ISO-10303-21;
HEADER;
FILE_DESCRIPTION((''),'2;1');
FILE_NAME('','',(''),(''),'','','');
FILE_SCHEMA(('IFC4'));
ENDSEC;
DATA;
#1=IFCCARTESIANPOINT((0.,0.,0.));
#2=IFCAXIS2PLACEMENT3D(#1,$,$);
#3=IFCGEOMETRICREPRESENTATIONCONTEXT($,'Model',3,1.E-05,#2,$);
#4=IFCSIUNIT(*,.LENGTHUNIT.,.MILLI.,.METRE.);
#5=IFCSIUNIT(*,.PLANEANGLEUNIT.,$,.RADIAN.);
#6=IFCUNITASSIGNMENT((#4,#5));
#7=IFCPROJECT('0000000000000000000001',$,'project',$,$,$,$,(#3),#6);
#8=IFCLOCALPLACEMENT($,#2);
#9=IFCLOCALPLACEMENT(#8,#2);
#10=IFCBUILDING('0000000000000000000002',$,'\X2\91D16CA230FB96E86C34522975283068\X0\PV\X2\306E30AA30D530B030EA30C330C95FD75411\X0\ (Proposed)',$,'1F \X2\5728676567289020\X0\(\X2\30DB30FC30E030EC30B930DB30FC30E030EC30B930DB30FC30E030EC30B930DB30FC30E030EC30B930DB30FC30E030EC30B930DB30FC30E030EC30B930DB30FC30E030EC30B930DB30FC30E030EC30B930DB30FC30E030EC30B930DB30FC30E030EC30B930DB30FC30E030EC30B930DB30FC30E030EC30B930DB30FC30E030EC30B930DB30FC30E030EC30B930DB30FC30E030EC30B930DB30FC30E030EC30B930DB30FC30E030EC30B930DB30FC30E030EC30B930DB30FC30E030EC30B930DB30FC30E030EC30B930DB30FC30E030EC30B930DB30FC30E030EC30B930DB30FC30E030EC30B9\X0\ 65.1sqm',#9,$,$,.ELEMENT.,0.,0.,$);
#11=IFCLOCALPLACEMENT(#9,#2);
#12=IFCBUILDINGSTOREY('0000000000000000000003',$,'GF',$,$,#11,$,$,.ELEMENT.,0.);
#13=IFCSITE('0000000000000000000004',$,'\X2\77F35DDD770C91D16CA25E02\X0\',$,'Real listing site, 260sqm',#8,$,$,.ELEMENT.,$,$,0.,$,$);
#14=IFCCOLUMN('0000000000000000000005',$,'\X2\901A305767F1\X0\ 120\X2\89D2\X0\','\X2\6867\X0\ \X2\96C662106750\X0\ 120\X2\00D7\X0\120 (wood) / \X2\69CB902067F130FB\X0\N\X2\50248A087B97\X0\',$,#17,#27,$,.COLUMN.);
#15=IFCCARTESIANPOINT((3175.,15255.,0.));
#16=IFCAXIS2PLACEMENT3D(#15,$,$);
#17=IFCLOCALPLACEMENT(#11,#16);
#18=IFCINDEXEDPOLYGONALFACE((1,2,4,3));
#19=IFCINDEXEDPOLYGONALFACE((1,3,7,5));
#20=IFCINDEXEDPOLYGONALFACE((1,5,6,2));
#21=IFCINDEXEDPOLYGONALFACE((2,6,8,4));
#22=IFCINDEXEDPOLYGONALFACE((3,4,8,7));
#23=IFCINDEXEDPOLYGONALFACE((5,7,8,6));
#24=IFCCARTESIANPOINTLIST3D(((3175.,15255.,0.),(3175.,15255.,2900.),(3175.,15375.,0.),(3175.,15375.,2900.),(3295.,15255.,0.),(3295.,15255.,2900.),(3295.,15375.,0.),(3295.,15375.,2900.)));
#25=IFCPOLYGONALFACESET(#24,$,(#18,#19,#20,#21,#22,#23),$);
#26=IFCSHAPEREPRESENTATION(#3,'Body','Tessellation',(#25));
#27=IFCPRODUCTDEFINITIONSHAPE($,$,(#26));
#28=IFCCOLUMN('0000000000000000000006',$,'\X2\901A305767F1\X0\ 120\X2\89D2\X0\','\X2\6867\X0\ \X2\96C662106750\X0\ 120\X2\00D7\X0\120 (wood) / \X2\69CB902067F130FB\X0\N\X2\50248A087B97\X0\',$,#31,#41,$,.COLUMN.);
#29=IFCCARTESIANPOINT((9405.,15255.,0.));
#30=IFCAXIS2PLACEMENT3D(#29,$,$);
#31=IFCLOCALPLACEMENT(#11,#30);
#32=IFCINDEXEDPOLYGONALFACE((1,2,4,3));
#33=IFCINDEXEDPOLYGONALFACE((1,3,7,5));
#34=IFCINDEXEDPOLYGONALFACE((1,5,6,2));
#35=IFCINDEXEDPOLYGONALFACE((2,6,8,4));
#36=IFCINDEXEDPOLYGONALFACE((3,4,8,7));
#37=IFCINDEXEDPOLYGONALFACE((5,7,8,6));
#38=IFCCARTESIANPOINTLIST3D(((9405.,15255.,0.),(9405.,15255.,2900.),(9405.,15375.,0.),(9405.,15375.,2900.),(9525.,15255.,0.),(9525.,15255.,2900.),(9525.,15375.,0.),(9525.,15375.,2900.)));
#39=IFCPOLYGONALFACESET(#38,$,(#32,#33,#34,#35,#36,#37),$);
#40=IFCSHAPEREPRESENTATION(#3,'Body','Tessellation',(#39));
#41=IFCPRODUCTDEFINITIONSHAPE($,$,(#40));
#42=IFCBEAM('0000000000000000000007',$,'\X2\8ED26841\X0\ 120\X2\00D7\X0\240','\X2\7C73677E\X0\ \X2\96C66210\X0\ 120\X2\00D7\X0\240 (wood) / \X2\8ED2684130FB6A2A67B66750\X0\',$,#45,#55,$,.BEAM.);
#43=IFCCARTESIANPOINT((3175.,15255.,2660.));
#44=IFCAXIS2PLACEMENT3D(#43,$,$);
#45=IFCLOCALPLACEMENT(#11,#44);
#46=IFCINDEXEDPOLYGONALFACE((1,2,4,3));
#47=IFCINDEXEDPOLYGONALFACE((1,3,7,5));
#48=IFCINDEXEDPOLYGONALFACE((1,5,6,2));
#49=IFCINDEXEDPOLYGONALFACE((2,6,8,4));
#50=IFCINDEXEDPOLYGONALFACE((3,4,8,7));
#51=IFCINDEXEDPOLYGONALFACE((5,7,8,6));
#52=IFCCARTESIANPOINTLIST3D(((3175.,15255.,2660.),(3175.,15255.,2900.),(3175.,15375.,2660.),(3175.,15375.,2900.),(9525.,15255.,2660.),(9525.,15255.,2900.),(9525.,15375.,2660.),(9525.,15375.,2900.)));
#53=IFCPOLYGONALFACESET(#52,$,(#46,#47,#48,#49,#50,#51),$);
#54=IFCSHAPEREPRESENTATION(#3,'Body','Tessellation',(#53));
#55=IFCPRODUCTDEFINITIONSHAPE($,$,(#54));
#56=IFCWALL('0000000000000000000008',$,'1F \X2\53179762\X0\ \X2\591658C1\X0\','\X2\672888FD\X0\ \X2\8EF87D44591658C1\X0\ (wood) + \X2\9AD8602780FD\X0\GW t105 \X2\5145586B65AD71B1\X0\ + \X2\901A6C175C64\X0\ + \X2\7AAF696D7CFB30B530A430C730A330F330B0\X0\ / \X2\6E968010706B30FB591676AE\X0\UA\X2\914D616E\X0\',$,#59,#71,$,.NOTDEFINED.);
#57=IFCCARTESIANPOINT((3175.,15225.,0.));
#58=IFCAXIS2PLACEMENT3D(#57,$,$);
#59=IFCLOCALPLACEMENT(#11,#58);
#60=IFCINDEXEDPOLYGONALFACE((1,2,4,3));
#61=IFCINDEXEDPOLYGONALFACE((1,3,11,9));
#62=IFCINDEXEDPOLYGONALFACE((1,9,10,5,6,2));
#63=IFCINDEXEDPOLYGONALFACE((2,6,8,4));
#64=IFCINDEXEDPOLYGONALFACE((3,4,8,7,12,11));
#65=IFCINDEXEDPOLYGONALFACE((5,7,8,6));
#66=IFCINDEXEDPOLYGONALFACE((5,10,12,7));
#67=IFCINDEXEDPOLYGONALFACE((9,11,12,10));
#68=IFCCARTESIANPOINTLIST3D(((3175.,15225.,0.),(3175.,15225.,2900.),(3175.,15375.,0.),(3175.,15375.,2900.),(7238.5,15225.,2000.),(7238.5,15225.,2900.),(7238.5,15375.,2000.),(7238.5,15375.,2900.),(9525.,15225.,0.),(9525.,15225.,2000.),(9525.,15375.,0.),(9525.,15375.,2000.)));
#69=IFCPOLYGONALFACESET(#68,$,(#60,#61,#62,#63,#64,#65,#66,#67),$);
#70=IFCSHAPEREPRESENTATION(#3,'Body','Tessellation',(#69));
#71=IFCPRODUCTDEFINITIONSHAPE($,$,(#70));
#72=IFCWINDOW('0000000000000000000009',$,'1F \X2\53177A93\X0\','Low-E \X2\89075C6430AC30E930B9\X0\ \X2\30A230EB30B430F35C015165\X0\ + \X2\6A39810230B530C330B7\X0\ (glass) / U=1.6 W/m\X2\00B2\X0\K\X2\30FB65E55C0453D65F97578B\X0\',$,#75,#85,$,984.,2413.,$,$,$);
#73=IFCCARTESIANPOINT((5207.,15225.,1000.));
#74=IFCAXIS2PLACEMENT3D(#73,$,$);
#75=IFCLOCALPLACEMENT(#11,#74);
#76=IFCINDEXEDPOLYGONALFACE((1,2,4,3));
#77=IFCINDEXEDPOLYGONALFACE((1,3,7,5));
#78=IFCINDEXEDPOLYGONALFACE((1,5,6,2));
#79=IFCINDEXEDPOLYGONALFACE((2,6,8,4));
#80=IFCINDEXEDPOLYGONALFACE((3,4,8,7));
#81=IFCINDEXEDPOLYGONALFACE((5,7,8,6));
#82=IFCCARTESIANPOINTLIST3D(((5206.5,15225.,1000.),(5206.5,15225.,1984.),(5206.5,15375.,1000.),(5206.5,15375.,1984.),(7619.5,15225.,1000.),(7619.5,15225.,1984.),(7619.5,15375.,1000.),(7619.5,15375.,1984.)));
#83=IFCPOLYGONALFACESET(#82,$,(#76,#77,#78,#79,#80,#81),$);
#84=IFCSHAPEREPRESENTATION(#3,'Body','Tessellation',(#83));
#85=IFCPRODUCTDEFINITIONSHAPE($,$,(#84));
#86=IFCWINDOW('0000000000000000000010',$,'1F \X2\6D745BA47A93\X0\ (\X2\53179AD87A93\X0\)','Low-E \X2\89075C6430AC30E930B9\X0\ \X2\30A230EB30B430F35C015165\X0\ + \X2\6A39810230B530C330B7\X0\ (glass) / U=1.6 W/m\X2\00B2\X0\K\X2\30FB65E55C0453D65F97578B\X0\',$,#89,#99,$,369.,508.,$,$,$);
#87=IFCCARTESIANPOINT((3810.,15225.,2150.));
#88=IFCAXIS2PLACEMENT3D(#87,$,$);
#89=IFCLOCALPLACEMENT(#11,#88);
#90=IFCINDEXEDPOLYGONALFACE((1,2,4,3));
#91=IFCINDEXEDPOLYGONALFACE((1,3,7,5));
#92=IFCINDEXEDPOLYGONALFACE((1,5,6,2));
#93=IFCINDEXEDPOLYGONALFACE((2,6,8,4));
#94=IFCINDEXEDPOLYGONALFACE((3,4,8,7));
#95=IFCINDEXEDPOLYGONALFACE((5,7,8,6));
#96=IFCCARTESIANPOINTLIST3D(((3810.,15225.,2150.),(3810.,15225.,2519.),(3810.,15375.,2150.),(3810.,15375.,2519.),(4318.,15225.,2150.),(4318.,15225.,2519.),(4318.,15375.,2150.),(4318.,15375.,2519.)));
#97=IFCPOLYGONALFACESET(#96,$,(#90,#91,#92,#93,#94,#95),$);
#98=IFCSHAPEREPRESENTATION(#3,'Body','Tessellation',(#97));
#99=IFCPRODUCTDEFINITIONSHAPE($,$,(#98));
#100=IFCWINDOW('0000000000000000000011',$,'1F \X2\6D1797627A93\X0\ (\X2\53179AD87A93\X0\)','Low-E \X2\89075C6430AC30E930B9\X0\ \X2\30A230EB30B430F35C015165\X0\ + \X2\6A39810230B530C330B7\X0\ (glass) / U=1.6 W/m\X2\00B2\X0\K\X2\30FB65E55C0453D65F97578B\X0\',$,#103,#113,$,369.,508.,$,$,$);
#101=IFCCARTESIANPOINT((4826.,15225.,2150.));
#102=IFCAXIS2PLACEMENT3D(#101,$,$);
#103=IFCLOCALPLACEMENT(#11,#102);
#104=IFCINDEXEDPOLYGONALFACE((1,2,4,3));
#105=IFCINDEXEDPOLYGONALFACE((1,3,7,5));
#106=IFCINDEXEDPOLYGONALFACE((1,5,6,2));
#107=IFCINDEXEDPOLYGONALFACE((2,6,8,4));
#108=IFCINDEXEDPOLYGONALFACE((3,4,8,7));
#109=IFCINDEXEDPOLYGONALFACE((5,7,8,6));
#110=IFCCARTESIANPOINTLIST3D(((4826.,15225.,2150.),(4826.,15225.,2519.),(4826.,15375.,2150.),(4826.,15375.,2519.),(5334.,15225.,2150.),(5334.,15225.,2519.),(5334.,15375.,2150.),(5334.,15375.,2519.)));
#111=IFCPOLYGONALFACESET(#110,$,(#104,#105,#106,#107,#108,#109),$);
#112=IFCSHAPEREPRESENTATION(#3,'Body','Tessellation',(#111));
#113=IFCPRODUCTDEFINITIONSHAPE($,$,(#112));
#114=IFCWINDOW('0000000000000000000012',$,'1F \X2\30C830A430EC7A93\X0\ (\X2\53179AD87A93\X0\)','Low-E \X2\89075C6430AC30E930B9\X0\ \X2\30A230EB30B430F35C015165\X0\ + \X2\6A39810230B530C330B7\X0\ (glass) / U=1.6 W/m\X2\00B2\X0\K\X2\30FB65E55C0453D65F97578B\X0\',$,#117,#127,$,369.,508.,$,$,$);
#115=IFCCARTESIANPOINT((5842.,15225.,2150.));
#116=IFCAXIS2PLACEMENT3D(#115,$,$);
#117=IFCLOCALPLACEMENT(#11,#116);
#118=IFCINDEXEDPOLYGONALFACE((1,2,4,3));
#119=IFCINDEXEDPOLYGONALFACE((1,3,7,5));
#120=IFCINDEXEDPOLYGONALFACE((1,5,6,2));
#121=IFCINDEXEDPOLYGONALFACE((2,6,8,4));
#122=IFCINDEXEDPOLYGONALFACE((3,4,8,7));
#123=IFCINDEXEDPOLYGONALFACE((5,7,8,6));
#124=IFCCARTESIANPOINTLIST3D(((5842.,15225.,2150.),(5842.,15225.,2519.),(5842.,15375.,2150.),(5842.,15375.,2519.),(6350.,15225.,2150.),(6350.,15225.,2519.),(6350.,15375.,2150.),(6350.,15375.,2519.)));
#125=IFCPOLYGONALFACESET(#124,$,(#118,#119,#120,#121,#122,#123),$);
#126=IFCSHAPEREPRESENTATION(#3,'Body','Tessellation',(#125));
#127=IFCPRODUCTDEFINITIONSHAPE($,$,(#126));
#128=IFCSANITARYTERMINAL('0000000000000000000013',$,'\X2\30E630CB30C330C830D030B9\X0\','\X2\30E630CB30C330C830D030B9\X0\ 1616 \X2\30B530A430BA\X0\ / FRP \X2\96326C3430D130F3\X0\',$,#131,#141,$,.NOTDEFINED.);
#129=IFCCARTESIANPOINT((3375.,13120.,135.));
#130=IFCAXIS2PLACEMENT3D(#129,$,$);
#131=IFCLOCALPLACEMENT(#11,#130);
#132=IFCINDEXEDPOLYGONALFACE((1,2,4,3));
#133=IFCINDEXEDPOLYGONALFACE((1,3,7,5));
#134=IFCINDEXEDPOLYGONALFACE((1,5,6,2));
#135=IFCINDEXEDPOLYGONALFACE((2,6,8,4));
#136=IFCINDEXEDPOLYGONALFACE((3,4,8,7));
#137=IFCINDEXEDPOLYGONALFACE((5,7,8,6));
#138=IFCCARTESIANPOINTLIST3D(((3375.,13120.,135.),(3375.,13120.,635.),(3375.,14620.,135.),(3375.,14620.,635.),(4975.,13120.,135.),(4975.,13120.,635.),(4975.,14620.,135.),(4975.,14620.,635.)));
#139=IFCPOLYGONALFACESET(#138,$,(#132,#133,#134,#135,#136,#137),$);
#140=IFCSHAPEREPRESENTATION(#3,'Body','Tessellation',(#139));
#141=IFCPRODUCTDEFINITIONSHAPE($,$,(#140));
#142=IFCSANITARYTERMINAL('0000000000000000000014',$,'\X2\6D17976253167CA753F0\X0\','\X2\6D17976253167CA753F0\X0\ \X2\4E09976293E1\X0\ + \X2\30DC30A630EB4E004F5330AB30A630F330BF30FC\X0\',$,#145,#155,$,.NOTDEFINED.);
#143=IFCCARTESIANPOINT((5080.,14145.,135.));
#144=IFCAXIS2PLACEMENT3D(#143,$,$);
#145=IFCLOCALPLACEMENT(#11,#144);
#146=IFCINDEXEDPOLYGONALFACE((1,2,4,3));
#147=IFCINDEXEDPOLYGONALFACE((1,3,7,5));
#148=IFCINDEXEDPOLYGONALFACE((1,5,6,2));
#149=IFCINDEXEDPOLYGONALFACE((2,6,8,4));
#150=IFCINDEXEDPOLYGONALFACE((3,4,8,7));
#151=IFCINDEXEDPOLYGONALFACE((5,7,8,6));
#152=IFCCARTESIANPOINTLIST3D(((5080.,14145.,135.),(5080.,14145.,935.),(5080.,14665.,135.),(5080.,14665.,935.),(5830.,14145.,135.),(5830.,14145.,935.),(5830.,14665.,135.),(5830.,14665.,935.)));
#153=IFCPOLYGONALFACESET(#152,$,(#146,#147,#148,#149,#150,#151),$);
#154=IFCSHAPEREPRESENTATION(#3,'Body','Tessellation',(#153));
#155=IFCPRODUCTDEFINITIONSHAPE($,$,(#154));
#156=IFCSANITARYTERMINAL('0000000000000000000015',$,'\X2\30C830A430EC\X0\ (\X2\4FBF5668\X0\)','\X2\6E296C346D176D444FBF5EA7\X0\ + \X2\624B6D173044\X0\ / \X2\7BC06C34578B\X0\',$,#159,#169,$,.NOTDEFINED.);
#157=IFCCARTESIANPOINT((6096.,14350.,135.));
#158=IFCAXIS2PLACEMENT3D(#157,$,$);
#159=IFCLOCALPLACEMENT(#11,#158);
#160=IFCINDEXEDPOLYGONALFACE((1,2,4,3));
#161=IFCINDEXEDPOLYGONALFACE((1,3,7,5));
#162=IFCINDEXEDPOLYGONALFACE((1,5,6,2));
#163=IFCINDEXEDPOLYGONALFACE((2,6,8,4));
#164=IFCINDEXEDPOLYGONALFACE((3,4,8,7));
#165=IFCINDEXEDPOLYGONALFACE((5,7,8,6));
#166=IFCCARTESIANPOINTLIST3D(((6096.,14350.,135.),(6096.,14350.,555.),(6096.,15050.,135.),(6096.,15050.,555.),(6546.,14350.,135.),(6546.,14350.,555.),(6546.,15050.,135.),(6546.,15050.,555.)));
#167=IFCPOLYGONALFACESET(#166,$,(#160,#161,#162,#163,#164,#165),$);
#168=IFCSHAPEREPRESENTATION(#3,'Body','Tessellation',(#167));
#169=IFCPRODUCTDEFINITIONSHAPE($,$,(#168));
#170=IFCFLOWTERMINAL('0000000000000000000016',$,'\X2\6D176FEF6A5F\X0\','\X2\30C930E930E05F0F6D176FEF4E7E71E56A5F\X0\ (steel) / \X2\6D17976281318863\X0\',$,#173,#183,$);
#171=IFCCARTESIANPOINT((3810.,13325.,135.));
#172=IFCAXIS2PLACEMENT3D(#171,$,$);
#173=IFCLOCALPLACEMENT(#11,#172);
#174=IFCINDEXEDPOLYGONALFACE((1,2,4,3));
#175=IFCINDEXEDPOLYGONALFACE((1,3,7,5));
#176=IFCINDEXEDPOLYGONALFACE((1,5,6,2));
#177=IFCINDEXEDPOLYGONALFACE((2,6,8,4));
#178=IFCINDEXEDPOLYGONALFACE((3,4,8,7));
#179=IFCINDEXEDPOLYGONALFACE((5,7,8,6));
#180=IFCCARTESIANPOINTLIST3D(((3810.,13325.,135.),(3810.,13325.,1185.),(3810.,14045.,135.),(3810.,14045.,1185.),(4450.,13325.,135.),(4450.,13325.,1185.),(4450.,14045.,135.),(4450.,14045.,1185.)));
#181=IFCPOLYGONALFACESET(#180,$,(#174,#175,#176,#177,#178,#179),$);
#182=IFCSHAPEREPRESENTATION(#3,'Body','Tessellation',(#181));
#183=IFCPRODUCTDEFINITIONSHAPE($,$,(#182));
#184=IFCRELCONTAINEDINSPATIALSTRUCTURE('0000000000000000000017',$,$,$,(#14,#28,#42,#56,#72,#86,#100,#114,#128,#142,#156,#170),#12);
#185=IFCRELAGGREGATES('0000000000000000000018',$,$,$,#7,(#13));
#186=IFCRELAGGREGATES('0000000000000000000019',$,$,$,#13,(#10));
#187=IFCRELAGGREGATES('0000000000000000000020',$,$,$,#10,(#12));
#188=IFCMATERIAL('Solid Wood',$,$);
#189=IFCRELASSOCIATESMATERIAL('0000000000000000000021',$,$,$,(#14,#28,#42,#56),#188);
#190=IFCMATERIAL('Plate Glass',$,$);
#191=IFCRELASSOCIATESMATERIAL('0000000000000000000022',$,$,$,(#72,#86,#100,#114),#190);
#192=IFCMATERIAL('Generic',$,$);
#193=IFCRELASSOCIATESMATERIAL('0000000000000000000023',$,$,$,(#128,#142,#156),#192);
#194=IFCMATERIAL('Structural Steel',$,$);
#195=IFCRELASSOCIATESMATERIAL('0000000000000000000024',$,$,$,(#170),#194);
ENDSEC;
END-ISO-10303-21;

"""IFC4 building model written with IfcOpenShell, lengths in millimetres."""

from ifc_helpers import new_model, si_unit, frame, frame_2d, origin, place, context, project, spatial, rectangle, extrude, material, element, fill, save


model = new_model("IFC4")

# Units and contexts
model_context = context("Model", 3, precision=1e-05, world=origin())
ifc_project = project(units=[si_unit("LENGTHUNIT", "METRE", prefix="MILLI"), si_unit("PLANEANGLEUNIT", "RADIAN")], contexts=[model_context])

# Site, building, storey
site_placement = place(None, origin())
site = spatial("IfcSite", under=ifc_project, at=site_placement, Name="石川県金沢市", ObjectType="Real listing site, 260sqm", CompositionType="ELEMENT", RefElevation=0.0)
building_placement = place(site_placement, origin())
building = spatial("IfcBuilding", under=site, at=building_placement, Name="金沢・雨水利用とPVのオフグリッド志向 (Proposed)", ObjectType="1F 在来木造(ホームレスホームレスホームレスホームレスホームレスホームレスホームレスホームレスホームレスホームレスホームレスホームレスホームレスホームレスホームレスホームレスホームレスホームレスホームレスホームレスホームレスホームレスホームレス 65.1sqm", CompositionType="ELEMENT", ElevationOfRefHeight=0.0, ElevationOfTerrain=0.0)
storey_placement = place(building_placement, origin())
storey = spatial("IfcBuildingStorey", under=building, at=storey_placement, Name="GF", CompositionType="ELEMENT", Elevation=0.0)

# Columns
ifc_material_1 = material(Name="Solid Wood")
column_1_placement = place(storey_placement, frame((3175.0, 15255.0, 0.0)))
element("IfcColumn", 1, at=column_1_placement, inside=storey, material=ifc_material_1, Name="通し柱 120角", Description="桧 集成材 120×120 (wood) / 構造柱・N値計算", PredefinedType="COLUMN", context=model_context, shape_type="SweptSolid", body=[
    extrude(rectangle(XDim=120.0, YDim=120.0, at=frame_2d((60.0, 60.0))), frame((3175.0, 15255.0, 0.0)), (0.0, 0.0, 1.0), 2900.0),
])
column_2_placement = place(storey_placement, frame((9405.0, 15255.0, 0.0)))
element("IfcColumn", 2, at=column_2_placement, inside=storey, material=ifc_material_1, Name="通し柱 120角", Description="桧 集成材 120×120 (wood) / 構造柱・N値計算", PredefinedType="COLUMN", context=model_context, shape_type="SweptSolid", body=[
    extrude(rectangle(XDim=120.0, YDim=120.0, at=frame_2d((60.0, 60.0))), frame((9405.0, 15255.0, 0.0)), (0.0, 0.0, 1.0), 2900.0),
])

# Beam
beam_1_placement = place(storey_placement, frame((3175.0, 15255.0, 2660.0)))
element("IfcBeam", 3, at=beam_1_placement, inside=storey, material=ifc_material_1, Name="軒桁 120×240", Description="米松 集成 120×240 (wood) / 軒桁・横架材", PredefinedType="BEAM", context=model_context, shape_type="SweptSolid", body=[
    extrude(rectangle(XDim=6350.0, YDim=120.0, at=frame_2d((3175.0, 60.0))), frame((3175.0, 15255.0, 2660.0)), (0.0, 0.0, 1.0), 240.0),
])

# Wall, openings, windows
wall_placement = place(storey_placement, frame((3175.0, 15225.0, 0.0)))
wall = element("IfcWall", 4, at=wall_placement, inside=storey, material=ifc_material_1, Name="1F 北面 外壁", Description="木製 軸組外壁 (wood) + 高性能GW t105 充填断熱 + 通気層 + 窯業系サイディング / 準耐火・外皮UA配慮", PredefinedType="NOTDEFINED", context=model_context, shape_type="SweptSolid", body=[
    extrude(rectangle(XDim=6350.0, YDim=150.0, at=frame_2d((3175.0, 75.0))), frame((3175.0, 15225.0, 0.0)), (0.0, 0.0, 1.0), 2900.0),
])
opening_1_placement = place(storey_placement, frame((5207.0, 15225.0, 1000.0)))
opening_1 = element("IfcOpeningElement", 5, at=opening_1_placement, cuts=wall, PredefinedType="NOTDEFINED", context=model_context, shape_type="SweptSolid", body=[
    extrude(rectangle(XDim=2413.0, YDim=150.0, at=frame_2d((1206.0, 75.0))), frame((5207.0, 15225.0, 1000.0)), (0.0, 0.0, 1.0), 984.0),
])
opening_2_placement = place(storey_placement, frame((3810.0, 15225.0, 2150.0)))
opening_2 = element("IfcOpeningElement", 6, at=opening_2_placement, cuts=wall, PredefinedType="NOTDEFINED", context=model_context, shape_type="SweptSolid", body=[
    extrude(rectangle(XDim=508.0, YDim=150.0, at=frame_2d((254.0, 75.0))), frame((3810.0, 15225.0, 2150.0)), (0.0, 0.0, 1.0), 369.0),
])
opening_3_placement = place(storey_placement, frame((4826.0, 15225.0, 2150.0)))
opening_3 = element("IfcOpeningElement", 7, at=opening_3_placement, cuts=wall, PredefinedType="NOTDEFINED", context=model_context, shape_type="SweptSolid", body=[
    extrude(rectangle(XDim=508.0, YDim=150.0, at=frame_2d((254.0, 75.0))), frame((4826.0, 15225.0, 2150.0)), (0.0, 0.0, 1.0), 369.0),
])
opening_4_placement = place(storey_placement, frame((5842.0, 15225.0, 2150.0)))
opening_4 = element("IfcOpeningElement", 8, at=opening_4_placement, cuts=wall, PredefinedType="NOTDEFINED", context=model_context, shape_type="SweptSolid", body=[
    extrude(rectangle(XDim=508.0, YDim=150.0, at=frame_2d((254.0, 75.0))), frame((5842.0, 15225.0, 2150.0)), (0.0, 0.0, 1.0), 369.0),
])
ifc_material_2 = material(Name="Plate Glass")
window_1_placement = place(storey_placement, frame((5207.0, 15225.0, 1000.0)))
window_1 = element("IfcWindow", 9, at=window_1_placement, inside=storey, material=ifc_material_2, Name="1F 北窓", Description="Low-E 複層ガラス アルゴン封入 + 樹脂サッシ (glass) / U=1.6 W/m²K・日射取得型", OverallHeight=984.0, OverallWidth=2413.0, context=model_context, shape_type="SweptSolid", body=[
    extrude(rectangle(XDim=2413.0, YDim=150.0, at=frame_2d((1206.0, 75.0))), frame((5207.0, 15225.0, 1000.0)), (0.0, 0.0, 1.0), 984.0),
])
fill(opening_1, window_1)
window_2_placement = place(storey_placement, frame((3810.0, 15225.0, 2150.0)))
window_2 = element("IfcWindow", 10, at=window_2_placement, inside=storey, material=ifc_material_2, Name="1F 浴室窓 (北高窓)", Description="Low-E 複層ガラス アルゴン封入 + 樹脂サッシ (glass) / U=1.6 W/m²K・日射取得型", OverallHeight=369.0, OverallWidth=508.0, context=model_context, shape_type="SweptSolid", body=[
    extrude(rectangle(XDim=508.0, YDim=150.0, at=frame_2d((254.0, 75.0))), frame((3810.0, 15225.0, 2150.0)), (0.0, 0.0, 1.0), 369.0),
])
fill(opening_2, window_2)
window_3_placement = place(storey_placement, frame((4826.0, 15225.0, 2150.0)))
window_3 = element("IfcWindow", 11, at=window_3_placement, inside=storey, material=ifc_material_2, Name="1F 洗面窓 (北高窓)", Description="Low-E 複層ガラス アルゴン封入 + 樹脂サッシ (glass) / U=1.6 W/m²K・日射取得型", OverallHeight=369.0, OverallWidth=508.0, context=model_context, shape_type="SweptSolid", body=[
    extrude(rectangle(XDim=508.0, YDim=150.0, at=frame_2d((254.0, 75.0))), frame((4826.0, 15225.0, 2150.0)), (0.0, 0.0, 1.0), 369.0),
])
fill(opening_3, window_3)
window_4_placement = place(storey_placement, frame((5842.0, 15225.0, 2150.0)))
window_4 = element("IfcWindow", 12, at=window_4_placement, inside=storey, material=ifc_material_2, Name="1F トイレ窓 (北高窓)", Description="Low-E 複層ガラス アルゴン封入 + 樹脂サッシ (glass) / U=1.6 W/m²K・日射取得型", OverallHeight=369.0, OverallWidth=508.0, context=model_context, shape_type="SweptSolid", body=[
    extrude(rectangle(XDim=508.0, YDim=150.0, at=frame_2d((254.0, 75.0))), frame((5842.0, 15225.0, 2150.0)), (0.0, 0.0, 1.0), 369.0),
])
fill(opening_4, window_4)

# Sanitary terminals
ifc_material_3 = material(Name="Generic")
sanitary_terminal_1_placement = place(storey_placement, frame((3375.0, 13120.0, 135.0)))
element("IfcSanitaryTerminal", 13, at=sanitary_terminal_1_placement, inside=storey, material=ifc_material_3, Name="ユニットバス", Description="ユニットバス 1616 サイズ / FRP 防水パン", PredefinedType="NOTDEFINED", context=model_context, shape_type="SweptSolid", body=[
    extrude(rectangle(XDim=1600.0, YDim=1500.0, at=frame_2d((800.0, 750.0))), frame((3375.0, 13120.0, 135.0)), (0.0, 0.0, 1.0), 500.0),
])
sanitary_terminal_2_placement = place(storey_placement, frame((5080.0, 14145.0, 135.0)))
element("IfcSanitaryTerminal", 14, at=sanitary_terminal_2_placement, inside=storey, material=ifc_material_3, Name="洗面化粧台", Description="洗面化粧台 三面鏡 + ボウル一体カウンター", PredefinedType="NOTDEFINED", context=model_context, shape_type="SweptSolid", body=[
    extrude(rectangle(XDim=750.0, YDim=520.0, at=frame_2d((375.0, 260.0))), frame((5080.0, 14145.0, 135.0)), (0.0, 0.0, 1.0), 800.0),
])
sanitary_terminal_3_placement = place(storey_placement, frame((6096.0, 14350.0, 135.0)))
element("IfcSanitaryTerminal", 15, at=sanitary_terminal_3_placement, inside=storey, material=ifc_material_3, Name="トイレ (便器)", Description="温水洗浄便座 + 手洗い / 節水型", PredefinedType="NOTDEFINED", context=model_context, shape_type="SweptSolid", body=[
    extrude(rectangle(XDim=450.0, YDim=700.0, at=frame_2d((225.0, 350.0))), frame((6096.0, 14350.0, 135.0)), (0.0, 0.0, 1.0), 420.0),
])

# Flow terminal
ifc_material_4 = material(Name="Structural Steel")
flow_terminal_placement = place(storey_placement, frame((3810.0, 13325.0, 135.0)))
element("IfcFlowTerminal", 16, at=flow_terminal_placement, inside=storey, material=ifc_material_4, Name="洗濯機", Description="ドラム式洗濯乾燥機 (steel) / 洗面脱衣", context=model_context, shape_type="SweptSolid", body=[
    extrude(rectangle(XDim=640.0, YDim=720.0, at=frame_2d((320.0, 360.0))), frame((3810.0, 13325.0, 135.0)), (0.0, 0.0, 1.0), 1050.0),
])

save(model, "model.ifc")
